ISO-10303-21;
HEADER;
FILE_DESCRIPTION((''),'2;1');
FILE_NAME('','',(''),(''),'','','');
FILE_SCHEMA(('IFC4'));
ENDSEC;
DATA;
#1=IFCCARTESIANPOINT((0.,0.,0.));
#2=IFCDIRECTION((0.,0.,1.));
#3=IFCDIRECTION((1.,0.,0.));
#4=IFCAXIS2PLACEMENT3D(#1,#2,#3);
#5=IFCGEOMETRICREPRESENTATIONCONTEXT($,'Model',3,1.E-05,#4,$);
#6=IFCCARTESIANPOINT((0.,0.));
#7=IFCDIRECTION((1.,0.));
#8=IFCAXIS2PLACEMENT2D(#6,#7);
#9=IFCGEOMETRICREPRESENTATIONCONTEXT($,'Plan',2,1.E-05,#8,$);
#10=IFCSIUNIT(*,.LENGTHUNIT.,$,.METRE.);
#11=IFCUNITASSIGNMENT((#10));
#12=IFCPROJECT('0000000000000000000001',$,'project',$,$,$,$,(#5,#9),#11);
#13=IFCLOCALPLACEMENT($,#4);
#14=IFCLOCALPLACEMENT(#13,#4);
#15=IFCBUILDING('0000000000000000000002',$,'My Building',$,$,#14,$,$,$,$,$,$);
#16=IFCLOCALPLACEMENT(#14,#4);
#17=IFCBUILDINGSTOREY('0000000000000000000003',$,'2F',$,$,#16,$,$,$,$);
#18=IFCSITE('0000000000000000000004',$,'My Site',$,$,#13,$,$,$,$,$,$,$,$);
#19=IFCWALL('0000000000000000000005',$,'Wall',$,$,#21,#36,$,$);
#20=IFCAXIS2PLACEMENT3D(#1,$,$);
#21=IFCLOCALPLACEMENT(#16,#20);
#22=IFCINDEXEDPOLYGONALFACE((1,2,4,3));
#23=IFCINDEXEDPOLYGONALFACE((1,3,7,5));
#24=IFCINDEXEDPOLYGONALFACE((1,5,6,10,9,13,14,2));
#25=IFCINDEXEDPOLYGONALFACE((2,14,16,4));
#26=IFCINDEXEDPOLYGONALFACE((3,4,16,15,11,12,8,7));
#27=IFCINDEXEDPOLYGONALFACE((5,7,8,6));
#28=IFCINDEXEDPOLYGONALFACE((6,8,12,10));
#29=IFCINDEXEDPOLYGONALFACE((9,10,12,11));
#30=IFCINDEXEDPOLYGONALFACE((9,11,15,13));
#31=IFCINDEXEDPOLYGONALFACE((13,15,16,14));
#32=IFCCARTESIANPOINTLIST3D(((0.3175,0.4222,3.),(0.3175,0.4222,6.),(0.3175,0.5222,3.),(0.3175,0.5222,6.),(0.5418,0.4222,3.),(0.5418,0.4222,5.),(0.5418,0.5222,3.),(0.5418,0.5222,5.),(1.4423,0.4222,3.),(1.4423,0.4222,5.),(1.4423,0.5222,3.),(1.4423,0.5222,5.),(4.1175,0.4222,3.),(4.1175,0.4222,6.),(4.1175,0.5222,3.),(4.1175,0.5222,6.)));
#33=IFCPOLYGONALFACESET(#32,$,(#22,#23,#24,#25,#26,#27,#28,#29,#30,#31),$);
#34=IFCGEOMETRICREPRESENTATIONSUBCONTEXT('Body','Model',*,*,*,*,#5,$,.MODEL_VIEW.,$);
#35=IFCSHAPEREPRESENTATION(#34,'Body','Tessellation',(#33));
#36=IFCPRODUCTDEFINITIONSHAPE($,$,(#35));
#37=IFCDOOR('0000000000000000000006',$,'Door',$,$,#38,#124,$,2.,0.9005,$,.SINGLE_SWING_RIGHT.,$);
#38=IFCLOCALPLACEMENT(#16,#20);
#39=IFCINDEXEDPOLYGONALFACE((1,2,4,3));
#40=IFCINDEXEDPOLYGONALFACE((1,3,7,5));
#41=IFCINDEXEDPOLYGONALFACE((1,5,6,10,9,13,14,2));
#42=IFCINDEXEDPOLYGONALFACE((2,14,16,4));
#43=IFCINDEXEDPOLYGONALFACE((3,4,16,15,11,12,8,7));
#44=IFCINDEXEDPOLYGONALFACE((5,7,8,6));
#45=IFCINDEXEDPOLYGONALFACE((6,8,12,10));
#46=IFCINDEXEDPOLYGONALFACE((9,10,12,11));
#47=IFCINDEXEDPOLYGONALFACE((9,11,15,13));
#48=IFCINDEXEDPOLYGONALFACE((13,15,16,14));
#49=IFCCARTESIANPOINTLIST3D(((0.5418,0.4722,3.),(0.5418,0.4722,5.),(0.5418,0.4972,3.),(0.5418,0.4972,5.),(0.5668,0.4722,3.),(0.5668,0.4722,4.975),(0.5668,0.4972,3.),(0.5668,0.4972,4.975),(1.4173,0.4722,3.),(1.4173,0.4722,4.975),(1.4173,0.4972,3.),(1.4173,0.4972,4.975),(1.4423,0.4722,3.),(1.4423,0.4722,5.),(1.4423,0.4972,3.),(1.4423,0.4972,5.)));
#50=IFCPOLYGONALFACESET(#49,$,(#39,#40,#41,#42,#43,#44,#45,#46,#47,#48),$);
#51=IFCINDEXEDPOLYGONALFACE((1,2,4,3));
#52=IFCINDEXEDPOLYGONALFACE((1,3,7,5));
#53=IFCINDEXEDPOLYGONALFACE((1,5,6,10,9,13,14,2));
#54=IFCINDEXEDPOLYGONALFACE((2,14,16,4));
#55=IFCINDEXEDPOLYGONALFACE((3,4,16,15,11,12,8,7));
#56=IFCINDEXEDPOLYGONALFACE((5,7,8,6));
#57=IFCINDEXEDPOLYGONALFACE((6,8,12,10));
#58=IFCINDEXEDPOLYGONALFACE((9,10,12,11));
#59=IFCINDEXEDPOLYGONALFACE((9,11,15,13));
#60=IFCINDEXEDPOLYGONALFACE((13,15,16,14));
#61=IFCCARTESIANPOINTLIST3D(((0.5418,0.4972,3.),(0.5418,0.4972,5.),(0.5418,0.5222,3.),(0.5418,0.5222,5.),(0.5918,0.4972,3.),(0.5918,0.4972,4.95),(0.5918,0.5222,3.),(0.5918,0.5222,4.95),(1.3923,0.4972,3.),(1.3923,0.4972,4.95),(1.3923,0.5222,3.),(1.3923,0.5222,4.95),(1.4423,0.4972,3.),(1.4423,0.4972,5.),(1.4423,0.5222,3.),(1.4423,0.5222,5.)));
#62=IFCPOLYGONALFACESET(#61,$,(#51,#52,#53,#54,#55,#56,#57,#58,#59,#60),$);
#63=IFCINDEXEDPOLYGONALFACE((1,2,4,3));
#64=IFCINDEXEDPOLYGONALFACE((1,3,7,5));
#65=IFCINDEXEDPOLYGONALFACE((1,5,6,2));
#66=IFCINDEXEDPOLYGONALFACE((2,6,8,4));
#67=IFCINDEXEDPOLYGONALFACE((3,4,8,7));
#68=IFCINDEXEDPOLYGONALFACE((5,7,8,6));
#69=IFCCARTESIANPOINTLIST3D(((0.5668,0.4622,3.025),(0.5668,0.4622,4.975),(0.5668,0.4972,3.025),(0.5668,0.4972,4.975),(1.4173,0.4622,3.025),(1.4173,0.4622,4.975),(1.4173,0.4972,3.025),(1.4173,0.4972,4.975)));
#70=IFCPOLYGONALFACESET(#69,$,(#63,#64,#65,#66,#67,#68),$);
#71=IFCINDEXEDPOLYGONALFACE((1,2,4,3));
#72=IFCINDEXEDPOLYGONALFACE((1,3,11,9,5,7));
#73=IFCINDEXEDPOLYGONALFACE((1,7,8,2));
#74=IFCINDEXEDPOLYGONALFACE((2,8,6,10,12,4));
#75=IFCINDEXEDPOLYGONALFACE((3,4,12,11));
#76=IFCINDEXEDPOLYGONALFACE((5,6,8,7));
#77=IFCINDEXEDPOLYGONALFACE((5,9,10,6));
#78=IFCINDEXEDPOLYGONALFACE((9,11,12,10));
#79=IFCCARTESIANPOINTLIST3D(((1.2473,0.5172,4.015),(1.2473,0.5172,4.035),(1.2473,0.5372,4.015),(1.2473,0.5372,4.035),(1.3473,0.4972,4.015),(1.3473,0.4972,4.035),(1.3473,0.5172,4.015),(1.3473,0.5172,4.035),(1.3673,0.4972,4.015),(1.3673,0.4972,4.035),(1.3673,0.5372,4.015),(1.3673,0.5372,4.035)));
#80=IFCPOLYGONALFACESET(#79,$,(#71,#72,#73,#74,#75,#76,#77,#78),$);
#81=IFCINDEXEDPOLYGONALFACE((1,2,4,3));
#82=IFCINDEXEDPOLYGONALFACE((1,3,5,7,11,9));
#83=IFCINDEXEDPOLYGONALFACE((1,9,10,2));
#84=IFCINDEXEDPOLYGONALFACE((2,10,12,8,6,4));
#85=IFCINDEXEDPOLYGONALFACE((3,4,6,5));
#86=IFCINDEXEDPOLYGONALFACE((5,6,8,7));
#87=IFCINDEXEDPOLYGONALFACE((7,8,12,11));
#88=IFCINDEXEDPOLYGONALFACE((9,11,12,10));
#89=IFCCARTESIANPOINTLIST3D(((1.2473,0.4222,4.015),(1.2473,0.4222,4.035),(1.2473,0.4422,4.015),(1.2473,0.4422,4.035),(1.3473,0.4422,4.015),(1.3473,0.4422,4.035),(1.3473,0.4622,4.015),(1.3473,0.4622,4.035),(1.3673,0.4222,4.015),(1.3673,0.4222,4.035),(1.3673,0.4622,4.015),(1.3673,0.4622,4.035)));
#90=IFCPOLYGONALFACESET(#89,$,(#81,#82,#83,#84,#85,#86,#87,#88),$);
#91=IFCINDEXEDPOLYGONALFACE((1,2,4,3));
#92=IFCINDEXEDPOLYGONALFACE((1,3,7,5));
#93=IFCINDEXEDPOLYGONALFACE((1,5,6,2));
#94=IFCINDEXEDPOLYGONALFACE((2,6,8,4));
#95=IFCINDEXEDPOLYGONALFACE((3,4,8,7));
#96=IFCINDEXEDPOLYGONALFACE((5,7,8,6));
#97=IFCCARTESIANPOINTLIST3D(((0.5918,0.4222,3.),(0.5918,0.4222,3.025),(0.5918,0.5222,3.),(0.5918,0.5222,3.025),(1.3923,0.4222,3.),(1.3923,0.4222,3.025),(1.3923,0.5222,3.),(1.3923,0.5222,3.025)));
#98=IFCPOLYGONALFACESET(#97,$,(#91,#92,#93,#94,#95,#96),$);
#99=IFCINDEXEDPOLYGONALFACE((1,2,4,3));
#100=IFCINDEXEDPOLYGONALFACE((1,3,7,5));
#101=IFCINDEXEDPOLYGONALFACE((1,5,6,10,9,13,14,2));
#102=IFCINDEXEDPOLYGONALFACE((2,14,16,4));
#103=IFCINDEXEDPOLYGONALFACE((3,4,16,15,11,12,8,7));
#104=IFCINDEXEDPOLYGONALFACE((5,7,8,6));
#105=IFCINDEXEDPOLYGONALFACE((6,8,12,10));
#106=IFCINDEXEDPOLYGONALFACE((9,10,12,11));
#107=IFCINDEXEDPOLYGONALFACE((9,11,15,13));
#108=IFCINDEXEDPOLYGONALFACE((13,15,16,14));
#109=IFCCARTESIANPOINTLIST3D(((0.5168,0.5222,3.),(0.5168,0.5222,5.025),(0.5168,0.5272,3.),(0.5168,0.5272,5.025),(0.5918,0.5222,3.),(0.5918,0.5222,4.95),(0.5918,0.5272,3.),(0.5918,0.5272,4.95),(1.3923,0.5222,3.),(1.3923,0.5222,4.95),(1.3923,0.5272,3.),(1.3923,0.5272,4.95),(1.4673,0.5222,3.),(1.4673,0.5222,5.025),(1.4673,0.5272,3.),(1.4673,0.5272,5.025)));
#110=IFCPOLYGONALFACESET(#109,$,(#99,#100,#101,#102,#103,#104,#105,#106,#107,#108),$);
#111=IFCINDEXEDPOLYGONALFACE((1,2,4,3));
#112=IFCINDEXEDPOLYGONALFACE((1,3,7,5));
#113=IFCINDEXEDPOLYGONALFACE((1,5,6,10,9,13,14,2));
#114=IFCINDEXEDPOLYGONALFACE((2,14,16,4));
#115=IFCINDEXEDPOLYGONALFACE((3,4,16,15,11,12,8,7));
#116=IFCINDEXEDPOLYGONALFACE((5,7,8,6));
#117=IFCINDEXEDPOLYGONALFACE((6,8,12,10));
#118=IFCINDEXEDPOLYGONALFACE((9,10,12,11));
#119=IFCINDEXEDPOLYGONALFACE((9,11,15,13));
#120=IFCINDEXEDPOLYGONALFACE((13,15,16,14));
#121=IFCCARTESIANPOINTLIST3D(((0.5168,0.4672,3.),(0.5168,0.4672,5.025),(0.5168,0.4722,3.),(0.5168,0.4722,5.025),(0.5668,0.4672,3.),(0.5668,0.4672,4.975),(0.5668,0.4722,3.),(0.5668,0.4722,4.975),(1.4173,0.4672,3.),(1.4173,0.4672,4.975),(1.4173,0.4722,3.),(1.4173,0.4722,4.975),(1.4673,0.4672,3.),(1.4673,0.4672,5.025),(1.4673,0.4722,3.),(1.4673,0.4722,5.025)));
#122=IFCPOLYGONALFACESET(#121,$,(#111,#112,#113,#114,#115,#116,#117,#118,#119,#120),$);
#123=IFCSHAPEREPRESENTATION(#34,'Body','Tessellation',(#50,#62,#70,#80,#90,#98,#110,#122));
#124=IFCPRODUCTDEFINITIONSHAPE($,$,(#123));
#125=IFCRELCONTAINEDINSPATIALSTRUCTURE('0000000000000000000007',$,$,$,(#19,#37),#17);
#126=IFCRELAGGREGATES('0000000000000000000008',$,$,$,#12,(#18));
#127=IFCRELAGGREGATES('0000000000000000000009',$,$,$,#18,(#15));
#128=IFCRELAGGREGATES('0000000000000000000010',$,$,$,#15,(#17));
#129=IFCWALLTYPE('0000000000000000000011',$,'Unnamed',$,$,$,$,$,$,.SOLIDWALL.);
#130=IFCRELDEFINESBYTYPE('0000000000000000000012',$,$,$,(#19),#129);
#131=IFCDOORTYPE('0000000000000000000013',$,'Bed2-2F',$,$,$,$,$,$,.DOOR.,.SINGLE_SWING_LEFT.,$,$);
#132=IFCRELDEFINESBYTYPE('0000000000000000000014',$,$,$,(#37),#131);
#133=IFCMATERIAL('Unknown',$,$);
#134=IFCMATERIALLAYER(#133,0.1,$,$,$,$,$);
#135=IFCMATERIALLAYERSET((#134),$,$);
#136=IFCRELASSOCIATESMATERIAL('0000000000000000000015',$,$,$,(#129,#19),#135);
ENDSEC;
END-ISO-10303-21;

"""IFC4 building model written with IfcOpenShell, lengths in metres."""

from ifc_helpers import new_model, entity, si_unit, frame, origin_with_axes, origin_2d_with_axis, place, context, subcontext, project, spatial, line, indexed_curve, outline, extrude, shape, source, transform, mapped, material, layer, layer_set, layer_usage, type_object, type_shapes, element, fill, save


model = new_model("IFC4")

# Units and contexts
model_context = context("Model", 3, precision=1e-05, world=origin_with_axes())
plan_context = context("Plan", 2, precision=1e-05, world=origin_2d_with_axis())
body_context_1 = subcontext(model_context, "Body", "Model", "MODEL_VIEW")
body_context_2 = subcontext(plan_context, "Body", "Plan", "PLAN_VIEW")
ifc_project = project(units=[si_unit("LENGTHUNIT", "METRE")], contexts=[model_context, plan_context])

# Site, building, storey
site_placement = place(None, origin_with_axes())
site = spatial("IfcSite", under=ifc_project, at=site_placement, Name="My Site")
building_placement = place(site_placement, origin_with_axes())
building = spatial("IfcBuilding", under=site, at=building_placement, Name="My Building")
storey_placement = place(building_placement, origin_with_axes())
storey = spatial("IfcBuildingStorey", under=building, at=storey_placement, Name="2F")

# Shared definitions
ifc_material = material(Name="Unknown")

# Shared definitions
ifc_layer = layer(ifc_material, 0.1)
ifc_layer_set = layer_set([ifc_layer])
wall_type = type_object("IfcWallType", Name="Unnamed", PredefinedType="SOLIDWALL", material=ifc_layer_set)

# Wall, opening, door
ifc_layer_usage_1 = layer_usage(ifc_layer_set, "AXIS2", "POSITIVE", 0.0)
wall_1_placement = place(storey_placement, frame((0.2175, 0.4222, 3.0), z_axis=(0.0, 0.0, 1.0), x_axis=(1.0, 0.0, 0.0)))
wall_1 = element("IfcWall", 1, at=wall_1_placement, inside=storey, type_object=wall_type, material=ifc_layer_usage_1, Name="Wall", context=body_context_1, shape_type="SweptSolid", body=[
    extrude(outline(indexed_curve([(0.1, 0.0), (0.1, 0.1), (3.9, 0.1), (3.9, 0.0)], segments=[line(1, 2, 3, 4, 1)])), origin_with_axes(), (0.0, 0.0, 1.0), 3.0),
])
shared_shape_1 = source(origin_with_axes(), body_context_1, "Body", "SweptSolid", [
    extrude(outline(indexed_curve([(0.0, 0.0), (0.9005, 0.0), (0.9005, 2.0), (0.0, 2.0)], segments=[line(1, 2, 3, 4, 1)])), frame((0.0, -0.6, 0.0), z_axis=(0.0, -1.0, 0.0), x_axis=(1.0, 0.0, 0.0)), (0.0, 0.0, -1.0), 1.2),
])
opening_1_placement = place(wall_1_placement, frame((1.2248, 0.1, 0.0), z_axis=(0.0, 0.0, 1.0), x_axis=(-1.0, 0.0, 0.0)))
opening_1 = element("IfcOpeningElement", 2, at=opening_1_placement, cuts=wall_1, PredefinedType="OPENING", context=body_context_1, shape_type="MappedRepresentation", body=[
    mapped(shared_shape_1, transform((0.0, 0.0, 0.0), x_axis=(1.0, 0.0, 0.0), y_axis=(0.0, 1.0, 0.0), z_axis=(0.0, 0.0, 1.0), scale=1.0)),
])
door_type_1 = type_object("IfcDoorType", Name="Bed2-2F", OperationType="SINGLE_SWING_LEFT", PredefinedType="DOOR")
shared_shape_2 = source(origin_with_axes(), body_context_1, "Body", "SweptSolid", [
    extrude(outline(indexed_curve([(0.0, 0.0), (0.0, 2.0), (0.9005, 2.0), (0.9005, 0.0), (0.8755, 0.0), (0.8755, 1.975), (0.025, 1.975), (0.025, 0.0)], segments=[line(1, 2, 3, 4, 5, 6, 7, 8, 1)])), frame((0.0, 0.025, 0.0), z_axis=(0.0, -1.0, 0.0), x_axis=(1.0, 0.0, 0.0)), (0.0, 0.0, -1.0), 0.025),
    extrude(outline(indexed_curve([(0.0, 0.0), (0.0, 2.0), (0.9005, 2.0), (0.9005, 0.0), (0.8505, 0.0), (0.8505, 1.95), (0.05, 1.95), (0.05, 0.0)], segments=[line(1, 2, 3, 4, 5, 6, 7, 8, 1)])), frame((0.0, 0.0, 0.0), z_axis=(0.0, -1.0, 0.0), x_axis=(1.0, 0.0, 0.0)), (0.0, 0.0, -1.0), 0.025),
    extrude(outline(indexed_curve([(0.0, 0.0), (0.8505, 0.0), (0.8505, 0.035), (0.0, 0.035)], segments=[line(1, 2, 3, 4, 1)])), frame((0.025, 0.025, 0.025), z_axis=(0.0, 0.0, 1.0), x_axis=(1.0, 0.0, 0.0)), (0.0, 0.0, 1.0), 1.95),
    extrude(outline(indexed_curve([(0.0, 0.0), (0.0, -0.04), (0.12, -0.04), (0.12, -0.02), (0.02, -0.02), (0.02, 0.0)], segments=[line(1, 2, 3, 4, 5, 6, 1)])), frame((0.075, 0.025, 1.015), z_axis=(0.0, 0.0, 1.0), x_axis=(1.0, 0.0, 0.0)), (0.0, 0.0, 1.0), 0.02),
    extrude(outline(indexed_curve([(0.0, 0.0), (0.0, 0.04), (0.12, 0.04), (0.12, 0.02), (0.02, 0.02), (0.02, 0.0)], segments=[line(1, 2, 3, 4, 5, 6, 1)])), frame((0.075, 0.06, 1.015), z_axis=(0.0, 0.0, 1.0), x_axis=(1.0, 0.0, 0.0)), (0.0, 0.0, 1.0), 0.02),
    extrude(outline(indexed_curve([(0.0, 0.0), (0.8005, 0.0), (0.8005, 0.1), (0.0, 0.1)], segments=[line(1, 2, 3, 4, 1)])), frame((0.05, 0.0, 0.0), z_axis=(0.0, 0.0, 1.0), x_axis=(1.0, 0.0, 0.0)), (0.0, 0.0, 1.0), 0.025),
    extrude(outline(indexed_curve([(0.0, 0.0), (0.0, 2.025), (0.9505, 2.025), (0.9505, 0.0), (0.8755, 0.0), (0.8755, 1.95), (0.075, 1.95), (0.075, 0.0)], segments=[line(1, 2, 3, 4, 5, 6, 7, 8, 1)])), frame((-0.025, -0.005, 0.0), z_axis=(0.0, -1.0, 0.0), x_axis=(1.0, 0.0, 0.0)), (0.0, 0.0, -1.0), 0.005),
    extrude(outline(indexed_curve([(0.0, 0.0), (0.0, 2.025), (0.9505, 2.025), (0.9505, 0.0), (0.9005, 0.0), (0.9005, 1.975), (0.05, 1.975), (0.05, 0.0)], segments=[line(1, 2, 3, 4, 5, 6, 7, 8, 1)])), frame((-0.025, 0.05, 0.0), z_axis=(0.0, -1.0, 0.0), x_axis=(1.0, 0.0, 0.0)), (0.0, 0.0, -1.0), 0.005),
])
shared_shape_3 = source(origin_with_axes(), body_context_2, "Body", "Curve2D", [
    entity("IfcIndexedPolyCurve", entity("IfcCartesianPointList2D", [[0.0, 0.0], [0.0, 0.05], [0.025, 0.05], [0.025, 0.025], [0.05, 0.025], [0.05, 0.0]]), [entity("IfcLineIndex", [1, 2, 3, 4, 5, 6, 1])]),
    entity("IfcIndexedPolyCurve", entity("IfcCartesianPointList2D", [[0.9005, 0.0], [0.9005, 0.05], [0.8755, 0.05], [0.8755, 0.025], [0.8505, 0.025], [0.8505, 0.0]]), [entity("IfcLineIndex", [1, 2, 3, 4, 5, 6, 1])]),
    entity("IfcTrimmedCurve", entity("IfcEllipse", entity("IfcAxis2Placement2D", entity("IfcCartesianPoint", [0.8405, 0.05]), entity("IfcDirection", [1.0, 0.0])), 0.8155, 0.8505), [entity("IfcCartesianPoint", [0.8405, 0.9005])], [entity("IfcCartesianPoint", [0.025, 0.05])], True, "CARTESIAN"),
    entity("IfcIndexedPolyCurve", entity("IfcCartesianPointList2D", [[0.8755, 0.05], [0.8405, 0.05], [0.8405, 0.9005], [0.8755, 0.9005]]), [entity("IfcLineIndex", [1, 2, 3, 4, 1])]),
])
type_shapes(door_type_1, [shared_shape_2, shared_shape_3])
door_1_placement = place(opening_1_placement, frame((0.0, 0.0, 0.0), z_axis=(0.0, 0.0, 1.0), x_axis=(1.0, 0.0, 0.0)))
door_1 = element("IfcDoor", 3, at=door_1_placement, inside=storey, type_object=door_type_1, Name="Door", OperationType="SINGLE_SWING_RIGHT", OverallHeight=2.0, OverallWidth=0.9005, shapes=[
    shape(body_context_1, "Body", "MappedRepresentation", [mapped(shared_shape_2, transform((0.0, 0.0, 0.0), x_axis=(1.0, 0.0, 0.0), y_axis=(0.0, 1.0, 0.0), z_axis=(0.0, 0.0, 1.0), scale=1.0))]),
    shape(body_context_2, "Body", "MappedRepresentation", [mapped(shared_shape_3, transform((0.0, 0.0, 0.0), x_axis=(1.0, 0.0, 0.0), y_axis=(0.0, 1.0, 0.0), z_axis=(0.0, 0.0, 1.0), scale=1.0))]),
])
fill(opening_1, door_1)

save(model, "model.ifc")
